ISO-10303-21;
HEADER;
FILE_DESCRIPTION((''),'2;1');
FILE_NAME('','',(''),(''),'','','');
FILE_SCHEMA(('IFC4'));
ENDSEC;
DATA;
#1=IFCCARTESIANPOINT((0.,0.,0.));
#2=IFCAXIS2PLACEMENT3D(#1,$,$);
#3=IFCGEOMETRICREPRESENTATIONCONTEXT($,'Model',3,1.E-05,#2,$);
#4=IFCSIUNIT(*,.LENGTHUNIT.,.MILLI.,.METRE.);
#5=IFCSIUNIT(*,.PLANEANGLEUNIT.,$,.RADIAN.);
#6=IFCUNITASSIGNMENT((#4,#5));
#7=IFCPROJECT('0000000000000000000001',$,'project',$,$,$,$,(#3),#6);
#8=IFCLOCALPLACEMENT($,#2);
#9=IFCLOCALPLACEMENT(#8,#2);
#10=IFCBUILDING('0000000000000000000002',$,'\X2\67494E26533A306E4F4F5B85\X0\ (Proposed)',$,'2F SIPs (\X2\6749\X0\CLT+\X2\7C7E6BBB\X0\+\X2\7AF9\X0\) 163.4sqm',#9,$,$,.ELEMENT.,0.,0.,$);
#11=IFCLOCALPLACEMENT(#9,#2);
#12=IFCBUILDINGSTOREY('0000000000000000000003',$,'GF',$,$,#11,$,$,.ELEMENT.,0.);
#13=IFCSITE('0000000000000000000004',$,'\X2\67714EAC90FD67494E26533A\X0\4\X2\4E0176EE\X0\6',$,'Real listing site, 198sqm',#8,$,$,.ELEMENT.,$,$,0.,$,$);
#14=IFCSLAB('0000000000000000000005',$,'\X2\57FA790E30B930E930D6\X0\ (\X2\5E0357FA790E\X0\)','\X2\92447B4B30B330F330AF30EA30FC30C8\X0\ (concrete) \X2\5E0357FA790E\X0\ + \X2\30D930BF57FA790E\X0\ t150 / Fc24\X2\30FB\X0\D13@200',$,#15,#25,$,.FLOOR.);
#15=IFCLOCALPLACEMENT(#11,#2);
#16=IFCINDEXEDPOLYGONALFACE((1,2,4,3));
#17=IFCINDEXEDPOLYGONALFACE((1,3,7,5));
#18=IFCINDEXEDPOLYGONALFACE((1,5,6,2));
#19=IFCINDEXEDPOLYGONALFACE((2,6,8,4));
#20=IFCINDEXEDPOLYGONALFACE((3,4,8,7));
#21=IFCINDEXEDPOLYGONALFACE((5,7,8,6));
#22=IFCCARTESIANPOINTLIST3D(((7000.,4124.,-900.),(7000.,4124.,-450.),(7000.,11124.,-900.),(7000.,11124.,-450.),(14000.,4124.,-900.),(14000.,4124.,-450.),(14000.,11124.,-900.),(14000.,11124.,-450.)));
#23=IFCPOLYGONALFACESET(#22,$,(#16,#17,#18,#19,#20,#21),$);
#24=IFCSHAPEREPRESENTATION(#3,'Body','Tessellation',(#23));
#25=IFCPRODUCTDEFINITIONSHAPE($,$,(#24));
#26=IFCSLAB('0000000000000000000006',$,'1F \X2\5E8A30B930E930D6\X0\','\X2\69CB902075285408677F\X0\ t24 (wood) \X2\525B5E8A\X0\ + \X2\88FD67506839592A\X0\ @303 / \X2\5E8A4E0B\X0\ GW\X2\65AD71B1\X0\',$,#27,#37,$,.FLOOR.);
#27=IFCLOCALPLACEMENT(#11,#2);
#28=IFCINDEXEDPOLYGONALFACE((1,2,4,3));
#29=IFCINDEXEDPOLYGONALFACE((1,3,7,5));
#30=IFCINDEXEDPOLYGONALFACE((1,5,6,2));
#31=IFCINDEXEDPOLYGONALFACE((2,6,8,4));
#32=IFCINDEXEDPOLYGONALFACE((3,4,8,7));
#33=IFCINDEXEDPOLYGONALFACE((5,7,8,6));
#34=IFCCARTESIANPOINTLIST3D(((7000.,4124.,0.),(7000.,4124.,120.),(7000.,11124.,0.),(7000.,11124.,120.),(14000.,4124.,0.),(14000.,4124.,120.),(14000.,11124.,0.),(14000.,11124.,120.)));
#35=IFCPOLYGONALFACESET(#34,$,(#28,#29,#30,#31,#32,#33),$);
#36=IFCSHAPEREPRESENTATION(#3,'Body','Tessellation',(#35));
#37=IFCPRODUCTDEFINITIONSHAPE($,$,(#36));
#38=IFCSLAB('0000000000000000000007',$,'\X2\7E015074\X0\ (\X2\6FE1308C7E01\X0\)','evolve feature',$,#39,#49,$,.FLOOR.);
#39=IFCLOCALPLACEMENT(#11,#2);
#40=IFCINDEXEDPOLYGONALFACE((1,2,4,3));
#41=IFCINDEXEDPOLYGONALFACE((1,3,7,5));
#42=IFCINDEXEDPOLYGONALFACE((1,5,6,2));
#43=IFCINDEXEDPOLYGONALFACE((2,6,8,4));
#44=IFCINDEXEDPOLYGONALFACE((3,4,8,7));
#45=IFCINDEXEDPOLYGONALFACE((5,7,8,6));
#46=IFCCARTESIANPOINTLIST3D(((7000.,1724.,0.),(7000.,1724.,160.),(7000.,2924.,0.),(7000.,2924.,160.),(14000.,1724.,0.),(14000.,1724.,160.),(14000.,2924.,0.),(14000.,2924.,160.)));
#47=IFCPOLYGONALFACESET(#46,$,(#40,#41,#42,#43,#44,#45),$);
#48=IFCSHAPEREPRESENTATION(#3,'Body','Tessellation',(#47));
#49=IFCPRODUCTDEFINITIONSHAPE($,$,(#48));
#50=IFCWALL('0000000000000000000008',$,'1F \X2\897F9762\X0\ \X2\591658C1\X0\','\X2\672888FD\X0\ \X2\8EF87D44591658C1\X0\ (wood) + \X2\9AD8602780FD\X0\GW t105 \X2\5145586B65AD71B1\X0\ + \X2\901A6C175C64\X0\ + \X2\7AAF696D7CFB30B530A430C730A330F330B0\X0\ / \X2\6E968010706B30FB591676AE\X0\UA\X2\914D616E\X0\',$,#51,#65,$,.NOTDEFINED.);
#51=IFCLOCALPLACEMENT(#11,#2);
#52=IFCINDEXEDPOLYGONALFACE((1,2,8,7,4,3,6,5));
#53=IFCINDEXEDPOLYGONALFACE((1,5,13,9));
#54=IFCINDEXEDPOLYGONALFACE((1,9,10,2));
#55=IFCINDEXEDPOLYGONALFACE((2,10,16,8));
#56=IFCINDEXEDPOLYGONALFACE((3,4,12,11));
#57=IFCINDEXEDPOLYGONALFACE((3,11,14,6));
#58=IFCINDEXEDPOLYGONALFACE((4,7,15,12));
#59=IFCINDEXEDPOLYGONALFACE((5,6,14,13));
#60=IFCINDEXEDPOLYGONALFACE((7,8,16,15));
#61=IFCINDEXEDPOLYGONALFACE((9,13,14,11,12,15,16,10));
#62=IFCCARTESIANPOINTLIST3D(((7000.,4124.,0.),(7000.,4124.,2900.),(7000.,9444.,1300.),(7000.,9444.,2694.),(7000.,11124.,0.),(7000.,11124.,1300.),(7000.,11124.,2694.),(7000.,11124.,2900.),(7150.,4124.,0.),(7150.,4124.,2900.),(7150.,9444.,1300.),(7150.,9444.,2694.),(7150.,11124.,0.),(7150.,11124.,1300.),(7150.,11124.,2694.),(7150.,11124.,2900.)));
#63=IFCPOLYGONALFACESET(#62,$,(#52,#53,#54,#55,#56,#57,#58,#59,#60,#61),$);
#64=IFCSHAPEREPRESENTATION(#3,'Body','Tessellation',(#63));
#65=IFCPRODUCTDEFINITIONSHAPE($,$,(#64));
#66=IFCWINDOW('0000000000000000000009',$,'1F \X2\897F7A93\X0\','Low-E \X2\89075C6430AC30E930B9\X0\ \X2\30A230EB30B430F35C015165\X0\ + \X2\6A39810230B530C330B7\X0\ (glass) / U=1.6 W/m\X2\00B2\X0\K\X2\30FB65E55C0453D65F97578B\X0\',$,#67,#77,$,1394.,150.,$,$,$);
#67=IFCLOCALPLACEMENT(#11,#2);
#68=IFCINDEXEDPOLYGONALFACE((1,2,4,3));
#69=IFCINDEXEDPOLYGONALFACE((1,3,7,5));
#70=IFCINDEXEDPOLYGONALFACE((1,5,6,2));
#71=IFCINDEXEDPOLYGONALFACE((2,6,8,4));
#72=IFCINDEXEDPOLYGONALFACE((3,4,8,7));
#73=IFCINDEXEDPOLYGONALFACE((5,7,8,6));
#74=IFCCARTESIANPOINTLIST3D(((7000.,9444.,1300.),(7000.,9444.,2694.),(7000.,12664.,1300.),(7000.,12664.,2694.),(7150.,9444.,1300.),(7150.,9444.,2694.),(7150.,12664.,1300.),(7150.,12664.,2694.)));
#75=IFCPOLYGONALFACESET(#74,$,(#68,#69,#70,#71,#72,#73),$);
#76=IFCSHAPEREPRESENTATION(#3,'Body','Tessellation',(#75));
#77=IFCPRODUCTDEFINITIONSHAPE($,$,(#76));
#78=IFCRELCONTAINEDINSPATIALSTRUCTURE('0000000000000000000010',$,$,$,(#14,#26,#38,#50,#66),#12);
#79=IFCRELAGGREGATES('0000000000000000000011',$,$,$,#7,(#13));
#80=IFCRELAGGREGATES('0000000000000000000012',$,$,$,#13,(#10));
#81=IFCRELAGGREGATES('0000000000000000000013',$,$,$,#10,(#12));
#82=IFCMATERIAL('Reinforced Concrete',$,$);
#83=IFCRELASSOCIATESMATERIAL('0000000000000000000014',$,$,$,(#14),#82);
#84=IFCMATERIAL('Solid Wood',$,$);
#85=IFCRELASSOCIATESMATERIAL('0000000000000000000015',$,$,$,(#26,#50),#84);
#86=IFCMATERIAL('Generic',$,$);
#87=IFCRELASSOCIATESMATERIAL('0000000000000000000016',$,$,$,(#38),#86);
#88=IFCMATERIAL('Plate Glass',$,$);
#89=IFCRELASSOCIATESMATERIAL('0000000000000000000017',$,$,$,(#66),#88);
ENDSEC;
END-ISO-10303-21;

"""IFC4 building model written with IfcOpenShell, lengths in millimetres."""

from ifc_helpers import new_model, si_unit, frame, frame_2d, origin, place, context, project, spatial, rectangle, extrude, material, element, fill, save


model = new_model("IFC4")

# Units and contexts
model_context = context("Model", 3, precision=1e-05, world=origin())
ifc_project = project(units=[si_unit("LENGTHUNIT", "METRE", prefix="MILLI"), si_unit("PLANEANGLEUNIT", "RADIAN")], contexts=[model_context])

# Site, building, storey
site_placement = place(None, origin())
site = spatial("IfcSite", under=ifc_project, at=site_placement, Name="東京都杉並区4丁目6", ObjectType="Real listing site, 198sqm", CompositionType="ELEMENT", RefElevation=0.0)
building_placement = place(site_placement, origin())
building = spatial("IfcBuilding", under=site, at=building_placement, Name="杉並区の住宅 (Proposed)", ObjectType="2F SIPs (杉CLT+籾殻+竹) 163.4sqm", CompositionType="ELEMENT", ElevationOfRefHeight=0.0, ElevationOfTerrain=0.0)
storey_placement = place(building_placement, origin())
storey = spatial("IfcBuildingStorey", under=building, at=storey_placement, Name="GF", CompositionType="ELEMENT", Elevation=0.0)

# Slabs
ifc_material_1 = material(Name="Reinforced Concrete")
slab_1_placement = place(storey_placement, frame((3500.0, 2062.0, -450.0)))
element("IfcSlab", 1, at=slab_1_placement, inside=storey, material=ifc_material_1, Name="基礎スラブ (布基礎)", Description="鉄筋コンクリート (concrete) 布基礎 + ベタ基礎 t150 / Fc24・D13@200", PredefinedType="FLOOR", context=model_context, shape_type="SweptSolid", body=[
    extrude(rectangle(XDim=7000.0, YDim=7000.0, at=frame_2d((3500.0, 3500.0))), frame((3500.0, 2062.0, -450.0)), (0.0, 0.0, 1.0), 450.0),
])
ifc_material_2 = material(Name="Solid Wood")
slab_2_placement = place(storey_placement, frame((3500.0, 2062.0, 0.0)))
element("IfcSlab", 2, at=slab_2_placement, inside=storey, material=ifc_material_2, Name="1F 床スラブ", Description="構造用合板 t24 (wood) 剛床 + 製材根太 @303 / 床下 GW断熱", PredefinedType="FLOOR", context=model_context, shape_type="SweptSolid", body=[
    extrude(rectangle(XDim=7000.0, YDim=7000.0, at=frame_2d((3500.0, 3500.0))), frame((3500.0, 2062.0, 0.0)), (0.0, 0.0, 1.0), 120.0),
])
ifc_material_3 = material(Name="Generic")
slab_3_placement = place(storey_placement, frame((3500.0, 862.0, 0.0)))
element("IfcSlab", 3, at=slab_3_placement, inside=storey, material=ifc_material_3, Name="縁側 (濡れ縁)", Description="evolve feature", PredefinedType="FLOOR", context=model_context, shape_type="SweptSolid", body=[
    extrude(rectangle(XDim=7000.0, YDim=1200.0, at=frame_2d((3500.0, 600.0))), frame((3500.0, 862.0, 0.0)), (0.0, 0.0, 1.0), 160.0),
])

# Shared definitions
ifc_material_4 = material(Name="Plate Glass")

# Wall, opening, window
wall_1_placement = place(storey_placement, frame((3500.0, 2062.0, 0.0)))
wall_1 = element("IfcWall", 4, at=wall_1_placement, inside=storey, material=ifc_material_2, Name="1F 西面 外壁", Description="木製 軸組外壁 (wood) + 高性能GW t105 充填断熱 + 通気層 + 窯業系サイディング / 準耐火・外皮UA配慮", PredefinedType="NOTDEFINED", context=model_context, shape_type="SweptSolid", body=[
    extrude(rectangle(XDim=150.0, YDim=7000.0, at=frame_2d((75.0, 3500.0))), frame((3500.0, 2062.0, 0.0)), (0.0, 0.0, 1.0), 2900.0),
])
opening_1_placement = place(storey_placement, frame((3500.0, 4722.0, 650.0)))
opening_1 = element("IfcOpeningElement", 5, at=opening_1_placement, cuts=wall_1, PredefinedType="NOTDEFINED", context=model_context, shape_type="SweptSolid", body=[
    extrude(rectangle(XDim=150.0, YDim=3220.0, at=frame_2d((75.0, 1610.0))), frame((3500.0, 4722.0, 650.0)), (0.0, 0.0, 1.0), 1394.0),
])
window_1_placement = place(storey_placement, frame((3500.0, 4722.0, 650.0)))
window_1 = element("IfcWindow", 6, at=window_1_placement, inside=storey, material=ifc_material_4, Name="1F 西窓", Description="Low-E 複層ガラス アルゴン封入 + 樹脂サッシ (glass) / U=1.6 W/m²K・日射取得型", OverallHeight=1394.0, OverallWidth=150.0, context=model_context, shape_type="SweptSolid", body=[
    extrude(rectangle(XDim=150.0, YDim=3220.0, at=frame_2d((75.0, 1610.0))), frame((3500.0, 4722.0, 650.0)), (0.0, 0.0, 1.0), 1394.0),
])
fill(opening_1, window_1)

save(model, "model.ifc")
